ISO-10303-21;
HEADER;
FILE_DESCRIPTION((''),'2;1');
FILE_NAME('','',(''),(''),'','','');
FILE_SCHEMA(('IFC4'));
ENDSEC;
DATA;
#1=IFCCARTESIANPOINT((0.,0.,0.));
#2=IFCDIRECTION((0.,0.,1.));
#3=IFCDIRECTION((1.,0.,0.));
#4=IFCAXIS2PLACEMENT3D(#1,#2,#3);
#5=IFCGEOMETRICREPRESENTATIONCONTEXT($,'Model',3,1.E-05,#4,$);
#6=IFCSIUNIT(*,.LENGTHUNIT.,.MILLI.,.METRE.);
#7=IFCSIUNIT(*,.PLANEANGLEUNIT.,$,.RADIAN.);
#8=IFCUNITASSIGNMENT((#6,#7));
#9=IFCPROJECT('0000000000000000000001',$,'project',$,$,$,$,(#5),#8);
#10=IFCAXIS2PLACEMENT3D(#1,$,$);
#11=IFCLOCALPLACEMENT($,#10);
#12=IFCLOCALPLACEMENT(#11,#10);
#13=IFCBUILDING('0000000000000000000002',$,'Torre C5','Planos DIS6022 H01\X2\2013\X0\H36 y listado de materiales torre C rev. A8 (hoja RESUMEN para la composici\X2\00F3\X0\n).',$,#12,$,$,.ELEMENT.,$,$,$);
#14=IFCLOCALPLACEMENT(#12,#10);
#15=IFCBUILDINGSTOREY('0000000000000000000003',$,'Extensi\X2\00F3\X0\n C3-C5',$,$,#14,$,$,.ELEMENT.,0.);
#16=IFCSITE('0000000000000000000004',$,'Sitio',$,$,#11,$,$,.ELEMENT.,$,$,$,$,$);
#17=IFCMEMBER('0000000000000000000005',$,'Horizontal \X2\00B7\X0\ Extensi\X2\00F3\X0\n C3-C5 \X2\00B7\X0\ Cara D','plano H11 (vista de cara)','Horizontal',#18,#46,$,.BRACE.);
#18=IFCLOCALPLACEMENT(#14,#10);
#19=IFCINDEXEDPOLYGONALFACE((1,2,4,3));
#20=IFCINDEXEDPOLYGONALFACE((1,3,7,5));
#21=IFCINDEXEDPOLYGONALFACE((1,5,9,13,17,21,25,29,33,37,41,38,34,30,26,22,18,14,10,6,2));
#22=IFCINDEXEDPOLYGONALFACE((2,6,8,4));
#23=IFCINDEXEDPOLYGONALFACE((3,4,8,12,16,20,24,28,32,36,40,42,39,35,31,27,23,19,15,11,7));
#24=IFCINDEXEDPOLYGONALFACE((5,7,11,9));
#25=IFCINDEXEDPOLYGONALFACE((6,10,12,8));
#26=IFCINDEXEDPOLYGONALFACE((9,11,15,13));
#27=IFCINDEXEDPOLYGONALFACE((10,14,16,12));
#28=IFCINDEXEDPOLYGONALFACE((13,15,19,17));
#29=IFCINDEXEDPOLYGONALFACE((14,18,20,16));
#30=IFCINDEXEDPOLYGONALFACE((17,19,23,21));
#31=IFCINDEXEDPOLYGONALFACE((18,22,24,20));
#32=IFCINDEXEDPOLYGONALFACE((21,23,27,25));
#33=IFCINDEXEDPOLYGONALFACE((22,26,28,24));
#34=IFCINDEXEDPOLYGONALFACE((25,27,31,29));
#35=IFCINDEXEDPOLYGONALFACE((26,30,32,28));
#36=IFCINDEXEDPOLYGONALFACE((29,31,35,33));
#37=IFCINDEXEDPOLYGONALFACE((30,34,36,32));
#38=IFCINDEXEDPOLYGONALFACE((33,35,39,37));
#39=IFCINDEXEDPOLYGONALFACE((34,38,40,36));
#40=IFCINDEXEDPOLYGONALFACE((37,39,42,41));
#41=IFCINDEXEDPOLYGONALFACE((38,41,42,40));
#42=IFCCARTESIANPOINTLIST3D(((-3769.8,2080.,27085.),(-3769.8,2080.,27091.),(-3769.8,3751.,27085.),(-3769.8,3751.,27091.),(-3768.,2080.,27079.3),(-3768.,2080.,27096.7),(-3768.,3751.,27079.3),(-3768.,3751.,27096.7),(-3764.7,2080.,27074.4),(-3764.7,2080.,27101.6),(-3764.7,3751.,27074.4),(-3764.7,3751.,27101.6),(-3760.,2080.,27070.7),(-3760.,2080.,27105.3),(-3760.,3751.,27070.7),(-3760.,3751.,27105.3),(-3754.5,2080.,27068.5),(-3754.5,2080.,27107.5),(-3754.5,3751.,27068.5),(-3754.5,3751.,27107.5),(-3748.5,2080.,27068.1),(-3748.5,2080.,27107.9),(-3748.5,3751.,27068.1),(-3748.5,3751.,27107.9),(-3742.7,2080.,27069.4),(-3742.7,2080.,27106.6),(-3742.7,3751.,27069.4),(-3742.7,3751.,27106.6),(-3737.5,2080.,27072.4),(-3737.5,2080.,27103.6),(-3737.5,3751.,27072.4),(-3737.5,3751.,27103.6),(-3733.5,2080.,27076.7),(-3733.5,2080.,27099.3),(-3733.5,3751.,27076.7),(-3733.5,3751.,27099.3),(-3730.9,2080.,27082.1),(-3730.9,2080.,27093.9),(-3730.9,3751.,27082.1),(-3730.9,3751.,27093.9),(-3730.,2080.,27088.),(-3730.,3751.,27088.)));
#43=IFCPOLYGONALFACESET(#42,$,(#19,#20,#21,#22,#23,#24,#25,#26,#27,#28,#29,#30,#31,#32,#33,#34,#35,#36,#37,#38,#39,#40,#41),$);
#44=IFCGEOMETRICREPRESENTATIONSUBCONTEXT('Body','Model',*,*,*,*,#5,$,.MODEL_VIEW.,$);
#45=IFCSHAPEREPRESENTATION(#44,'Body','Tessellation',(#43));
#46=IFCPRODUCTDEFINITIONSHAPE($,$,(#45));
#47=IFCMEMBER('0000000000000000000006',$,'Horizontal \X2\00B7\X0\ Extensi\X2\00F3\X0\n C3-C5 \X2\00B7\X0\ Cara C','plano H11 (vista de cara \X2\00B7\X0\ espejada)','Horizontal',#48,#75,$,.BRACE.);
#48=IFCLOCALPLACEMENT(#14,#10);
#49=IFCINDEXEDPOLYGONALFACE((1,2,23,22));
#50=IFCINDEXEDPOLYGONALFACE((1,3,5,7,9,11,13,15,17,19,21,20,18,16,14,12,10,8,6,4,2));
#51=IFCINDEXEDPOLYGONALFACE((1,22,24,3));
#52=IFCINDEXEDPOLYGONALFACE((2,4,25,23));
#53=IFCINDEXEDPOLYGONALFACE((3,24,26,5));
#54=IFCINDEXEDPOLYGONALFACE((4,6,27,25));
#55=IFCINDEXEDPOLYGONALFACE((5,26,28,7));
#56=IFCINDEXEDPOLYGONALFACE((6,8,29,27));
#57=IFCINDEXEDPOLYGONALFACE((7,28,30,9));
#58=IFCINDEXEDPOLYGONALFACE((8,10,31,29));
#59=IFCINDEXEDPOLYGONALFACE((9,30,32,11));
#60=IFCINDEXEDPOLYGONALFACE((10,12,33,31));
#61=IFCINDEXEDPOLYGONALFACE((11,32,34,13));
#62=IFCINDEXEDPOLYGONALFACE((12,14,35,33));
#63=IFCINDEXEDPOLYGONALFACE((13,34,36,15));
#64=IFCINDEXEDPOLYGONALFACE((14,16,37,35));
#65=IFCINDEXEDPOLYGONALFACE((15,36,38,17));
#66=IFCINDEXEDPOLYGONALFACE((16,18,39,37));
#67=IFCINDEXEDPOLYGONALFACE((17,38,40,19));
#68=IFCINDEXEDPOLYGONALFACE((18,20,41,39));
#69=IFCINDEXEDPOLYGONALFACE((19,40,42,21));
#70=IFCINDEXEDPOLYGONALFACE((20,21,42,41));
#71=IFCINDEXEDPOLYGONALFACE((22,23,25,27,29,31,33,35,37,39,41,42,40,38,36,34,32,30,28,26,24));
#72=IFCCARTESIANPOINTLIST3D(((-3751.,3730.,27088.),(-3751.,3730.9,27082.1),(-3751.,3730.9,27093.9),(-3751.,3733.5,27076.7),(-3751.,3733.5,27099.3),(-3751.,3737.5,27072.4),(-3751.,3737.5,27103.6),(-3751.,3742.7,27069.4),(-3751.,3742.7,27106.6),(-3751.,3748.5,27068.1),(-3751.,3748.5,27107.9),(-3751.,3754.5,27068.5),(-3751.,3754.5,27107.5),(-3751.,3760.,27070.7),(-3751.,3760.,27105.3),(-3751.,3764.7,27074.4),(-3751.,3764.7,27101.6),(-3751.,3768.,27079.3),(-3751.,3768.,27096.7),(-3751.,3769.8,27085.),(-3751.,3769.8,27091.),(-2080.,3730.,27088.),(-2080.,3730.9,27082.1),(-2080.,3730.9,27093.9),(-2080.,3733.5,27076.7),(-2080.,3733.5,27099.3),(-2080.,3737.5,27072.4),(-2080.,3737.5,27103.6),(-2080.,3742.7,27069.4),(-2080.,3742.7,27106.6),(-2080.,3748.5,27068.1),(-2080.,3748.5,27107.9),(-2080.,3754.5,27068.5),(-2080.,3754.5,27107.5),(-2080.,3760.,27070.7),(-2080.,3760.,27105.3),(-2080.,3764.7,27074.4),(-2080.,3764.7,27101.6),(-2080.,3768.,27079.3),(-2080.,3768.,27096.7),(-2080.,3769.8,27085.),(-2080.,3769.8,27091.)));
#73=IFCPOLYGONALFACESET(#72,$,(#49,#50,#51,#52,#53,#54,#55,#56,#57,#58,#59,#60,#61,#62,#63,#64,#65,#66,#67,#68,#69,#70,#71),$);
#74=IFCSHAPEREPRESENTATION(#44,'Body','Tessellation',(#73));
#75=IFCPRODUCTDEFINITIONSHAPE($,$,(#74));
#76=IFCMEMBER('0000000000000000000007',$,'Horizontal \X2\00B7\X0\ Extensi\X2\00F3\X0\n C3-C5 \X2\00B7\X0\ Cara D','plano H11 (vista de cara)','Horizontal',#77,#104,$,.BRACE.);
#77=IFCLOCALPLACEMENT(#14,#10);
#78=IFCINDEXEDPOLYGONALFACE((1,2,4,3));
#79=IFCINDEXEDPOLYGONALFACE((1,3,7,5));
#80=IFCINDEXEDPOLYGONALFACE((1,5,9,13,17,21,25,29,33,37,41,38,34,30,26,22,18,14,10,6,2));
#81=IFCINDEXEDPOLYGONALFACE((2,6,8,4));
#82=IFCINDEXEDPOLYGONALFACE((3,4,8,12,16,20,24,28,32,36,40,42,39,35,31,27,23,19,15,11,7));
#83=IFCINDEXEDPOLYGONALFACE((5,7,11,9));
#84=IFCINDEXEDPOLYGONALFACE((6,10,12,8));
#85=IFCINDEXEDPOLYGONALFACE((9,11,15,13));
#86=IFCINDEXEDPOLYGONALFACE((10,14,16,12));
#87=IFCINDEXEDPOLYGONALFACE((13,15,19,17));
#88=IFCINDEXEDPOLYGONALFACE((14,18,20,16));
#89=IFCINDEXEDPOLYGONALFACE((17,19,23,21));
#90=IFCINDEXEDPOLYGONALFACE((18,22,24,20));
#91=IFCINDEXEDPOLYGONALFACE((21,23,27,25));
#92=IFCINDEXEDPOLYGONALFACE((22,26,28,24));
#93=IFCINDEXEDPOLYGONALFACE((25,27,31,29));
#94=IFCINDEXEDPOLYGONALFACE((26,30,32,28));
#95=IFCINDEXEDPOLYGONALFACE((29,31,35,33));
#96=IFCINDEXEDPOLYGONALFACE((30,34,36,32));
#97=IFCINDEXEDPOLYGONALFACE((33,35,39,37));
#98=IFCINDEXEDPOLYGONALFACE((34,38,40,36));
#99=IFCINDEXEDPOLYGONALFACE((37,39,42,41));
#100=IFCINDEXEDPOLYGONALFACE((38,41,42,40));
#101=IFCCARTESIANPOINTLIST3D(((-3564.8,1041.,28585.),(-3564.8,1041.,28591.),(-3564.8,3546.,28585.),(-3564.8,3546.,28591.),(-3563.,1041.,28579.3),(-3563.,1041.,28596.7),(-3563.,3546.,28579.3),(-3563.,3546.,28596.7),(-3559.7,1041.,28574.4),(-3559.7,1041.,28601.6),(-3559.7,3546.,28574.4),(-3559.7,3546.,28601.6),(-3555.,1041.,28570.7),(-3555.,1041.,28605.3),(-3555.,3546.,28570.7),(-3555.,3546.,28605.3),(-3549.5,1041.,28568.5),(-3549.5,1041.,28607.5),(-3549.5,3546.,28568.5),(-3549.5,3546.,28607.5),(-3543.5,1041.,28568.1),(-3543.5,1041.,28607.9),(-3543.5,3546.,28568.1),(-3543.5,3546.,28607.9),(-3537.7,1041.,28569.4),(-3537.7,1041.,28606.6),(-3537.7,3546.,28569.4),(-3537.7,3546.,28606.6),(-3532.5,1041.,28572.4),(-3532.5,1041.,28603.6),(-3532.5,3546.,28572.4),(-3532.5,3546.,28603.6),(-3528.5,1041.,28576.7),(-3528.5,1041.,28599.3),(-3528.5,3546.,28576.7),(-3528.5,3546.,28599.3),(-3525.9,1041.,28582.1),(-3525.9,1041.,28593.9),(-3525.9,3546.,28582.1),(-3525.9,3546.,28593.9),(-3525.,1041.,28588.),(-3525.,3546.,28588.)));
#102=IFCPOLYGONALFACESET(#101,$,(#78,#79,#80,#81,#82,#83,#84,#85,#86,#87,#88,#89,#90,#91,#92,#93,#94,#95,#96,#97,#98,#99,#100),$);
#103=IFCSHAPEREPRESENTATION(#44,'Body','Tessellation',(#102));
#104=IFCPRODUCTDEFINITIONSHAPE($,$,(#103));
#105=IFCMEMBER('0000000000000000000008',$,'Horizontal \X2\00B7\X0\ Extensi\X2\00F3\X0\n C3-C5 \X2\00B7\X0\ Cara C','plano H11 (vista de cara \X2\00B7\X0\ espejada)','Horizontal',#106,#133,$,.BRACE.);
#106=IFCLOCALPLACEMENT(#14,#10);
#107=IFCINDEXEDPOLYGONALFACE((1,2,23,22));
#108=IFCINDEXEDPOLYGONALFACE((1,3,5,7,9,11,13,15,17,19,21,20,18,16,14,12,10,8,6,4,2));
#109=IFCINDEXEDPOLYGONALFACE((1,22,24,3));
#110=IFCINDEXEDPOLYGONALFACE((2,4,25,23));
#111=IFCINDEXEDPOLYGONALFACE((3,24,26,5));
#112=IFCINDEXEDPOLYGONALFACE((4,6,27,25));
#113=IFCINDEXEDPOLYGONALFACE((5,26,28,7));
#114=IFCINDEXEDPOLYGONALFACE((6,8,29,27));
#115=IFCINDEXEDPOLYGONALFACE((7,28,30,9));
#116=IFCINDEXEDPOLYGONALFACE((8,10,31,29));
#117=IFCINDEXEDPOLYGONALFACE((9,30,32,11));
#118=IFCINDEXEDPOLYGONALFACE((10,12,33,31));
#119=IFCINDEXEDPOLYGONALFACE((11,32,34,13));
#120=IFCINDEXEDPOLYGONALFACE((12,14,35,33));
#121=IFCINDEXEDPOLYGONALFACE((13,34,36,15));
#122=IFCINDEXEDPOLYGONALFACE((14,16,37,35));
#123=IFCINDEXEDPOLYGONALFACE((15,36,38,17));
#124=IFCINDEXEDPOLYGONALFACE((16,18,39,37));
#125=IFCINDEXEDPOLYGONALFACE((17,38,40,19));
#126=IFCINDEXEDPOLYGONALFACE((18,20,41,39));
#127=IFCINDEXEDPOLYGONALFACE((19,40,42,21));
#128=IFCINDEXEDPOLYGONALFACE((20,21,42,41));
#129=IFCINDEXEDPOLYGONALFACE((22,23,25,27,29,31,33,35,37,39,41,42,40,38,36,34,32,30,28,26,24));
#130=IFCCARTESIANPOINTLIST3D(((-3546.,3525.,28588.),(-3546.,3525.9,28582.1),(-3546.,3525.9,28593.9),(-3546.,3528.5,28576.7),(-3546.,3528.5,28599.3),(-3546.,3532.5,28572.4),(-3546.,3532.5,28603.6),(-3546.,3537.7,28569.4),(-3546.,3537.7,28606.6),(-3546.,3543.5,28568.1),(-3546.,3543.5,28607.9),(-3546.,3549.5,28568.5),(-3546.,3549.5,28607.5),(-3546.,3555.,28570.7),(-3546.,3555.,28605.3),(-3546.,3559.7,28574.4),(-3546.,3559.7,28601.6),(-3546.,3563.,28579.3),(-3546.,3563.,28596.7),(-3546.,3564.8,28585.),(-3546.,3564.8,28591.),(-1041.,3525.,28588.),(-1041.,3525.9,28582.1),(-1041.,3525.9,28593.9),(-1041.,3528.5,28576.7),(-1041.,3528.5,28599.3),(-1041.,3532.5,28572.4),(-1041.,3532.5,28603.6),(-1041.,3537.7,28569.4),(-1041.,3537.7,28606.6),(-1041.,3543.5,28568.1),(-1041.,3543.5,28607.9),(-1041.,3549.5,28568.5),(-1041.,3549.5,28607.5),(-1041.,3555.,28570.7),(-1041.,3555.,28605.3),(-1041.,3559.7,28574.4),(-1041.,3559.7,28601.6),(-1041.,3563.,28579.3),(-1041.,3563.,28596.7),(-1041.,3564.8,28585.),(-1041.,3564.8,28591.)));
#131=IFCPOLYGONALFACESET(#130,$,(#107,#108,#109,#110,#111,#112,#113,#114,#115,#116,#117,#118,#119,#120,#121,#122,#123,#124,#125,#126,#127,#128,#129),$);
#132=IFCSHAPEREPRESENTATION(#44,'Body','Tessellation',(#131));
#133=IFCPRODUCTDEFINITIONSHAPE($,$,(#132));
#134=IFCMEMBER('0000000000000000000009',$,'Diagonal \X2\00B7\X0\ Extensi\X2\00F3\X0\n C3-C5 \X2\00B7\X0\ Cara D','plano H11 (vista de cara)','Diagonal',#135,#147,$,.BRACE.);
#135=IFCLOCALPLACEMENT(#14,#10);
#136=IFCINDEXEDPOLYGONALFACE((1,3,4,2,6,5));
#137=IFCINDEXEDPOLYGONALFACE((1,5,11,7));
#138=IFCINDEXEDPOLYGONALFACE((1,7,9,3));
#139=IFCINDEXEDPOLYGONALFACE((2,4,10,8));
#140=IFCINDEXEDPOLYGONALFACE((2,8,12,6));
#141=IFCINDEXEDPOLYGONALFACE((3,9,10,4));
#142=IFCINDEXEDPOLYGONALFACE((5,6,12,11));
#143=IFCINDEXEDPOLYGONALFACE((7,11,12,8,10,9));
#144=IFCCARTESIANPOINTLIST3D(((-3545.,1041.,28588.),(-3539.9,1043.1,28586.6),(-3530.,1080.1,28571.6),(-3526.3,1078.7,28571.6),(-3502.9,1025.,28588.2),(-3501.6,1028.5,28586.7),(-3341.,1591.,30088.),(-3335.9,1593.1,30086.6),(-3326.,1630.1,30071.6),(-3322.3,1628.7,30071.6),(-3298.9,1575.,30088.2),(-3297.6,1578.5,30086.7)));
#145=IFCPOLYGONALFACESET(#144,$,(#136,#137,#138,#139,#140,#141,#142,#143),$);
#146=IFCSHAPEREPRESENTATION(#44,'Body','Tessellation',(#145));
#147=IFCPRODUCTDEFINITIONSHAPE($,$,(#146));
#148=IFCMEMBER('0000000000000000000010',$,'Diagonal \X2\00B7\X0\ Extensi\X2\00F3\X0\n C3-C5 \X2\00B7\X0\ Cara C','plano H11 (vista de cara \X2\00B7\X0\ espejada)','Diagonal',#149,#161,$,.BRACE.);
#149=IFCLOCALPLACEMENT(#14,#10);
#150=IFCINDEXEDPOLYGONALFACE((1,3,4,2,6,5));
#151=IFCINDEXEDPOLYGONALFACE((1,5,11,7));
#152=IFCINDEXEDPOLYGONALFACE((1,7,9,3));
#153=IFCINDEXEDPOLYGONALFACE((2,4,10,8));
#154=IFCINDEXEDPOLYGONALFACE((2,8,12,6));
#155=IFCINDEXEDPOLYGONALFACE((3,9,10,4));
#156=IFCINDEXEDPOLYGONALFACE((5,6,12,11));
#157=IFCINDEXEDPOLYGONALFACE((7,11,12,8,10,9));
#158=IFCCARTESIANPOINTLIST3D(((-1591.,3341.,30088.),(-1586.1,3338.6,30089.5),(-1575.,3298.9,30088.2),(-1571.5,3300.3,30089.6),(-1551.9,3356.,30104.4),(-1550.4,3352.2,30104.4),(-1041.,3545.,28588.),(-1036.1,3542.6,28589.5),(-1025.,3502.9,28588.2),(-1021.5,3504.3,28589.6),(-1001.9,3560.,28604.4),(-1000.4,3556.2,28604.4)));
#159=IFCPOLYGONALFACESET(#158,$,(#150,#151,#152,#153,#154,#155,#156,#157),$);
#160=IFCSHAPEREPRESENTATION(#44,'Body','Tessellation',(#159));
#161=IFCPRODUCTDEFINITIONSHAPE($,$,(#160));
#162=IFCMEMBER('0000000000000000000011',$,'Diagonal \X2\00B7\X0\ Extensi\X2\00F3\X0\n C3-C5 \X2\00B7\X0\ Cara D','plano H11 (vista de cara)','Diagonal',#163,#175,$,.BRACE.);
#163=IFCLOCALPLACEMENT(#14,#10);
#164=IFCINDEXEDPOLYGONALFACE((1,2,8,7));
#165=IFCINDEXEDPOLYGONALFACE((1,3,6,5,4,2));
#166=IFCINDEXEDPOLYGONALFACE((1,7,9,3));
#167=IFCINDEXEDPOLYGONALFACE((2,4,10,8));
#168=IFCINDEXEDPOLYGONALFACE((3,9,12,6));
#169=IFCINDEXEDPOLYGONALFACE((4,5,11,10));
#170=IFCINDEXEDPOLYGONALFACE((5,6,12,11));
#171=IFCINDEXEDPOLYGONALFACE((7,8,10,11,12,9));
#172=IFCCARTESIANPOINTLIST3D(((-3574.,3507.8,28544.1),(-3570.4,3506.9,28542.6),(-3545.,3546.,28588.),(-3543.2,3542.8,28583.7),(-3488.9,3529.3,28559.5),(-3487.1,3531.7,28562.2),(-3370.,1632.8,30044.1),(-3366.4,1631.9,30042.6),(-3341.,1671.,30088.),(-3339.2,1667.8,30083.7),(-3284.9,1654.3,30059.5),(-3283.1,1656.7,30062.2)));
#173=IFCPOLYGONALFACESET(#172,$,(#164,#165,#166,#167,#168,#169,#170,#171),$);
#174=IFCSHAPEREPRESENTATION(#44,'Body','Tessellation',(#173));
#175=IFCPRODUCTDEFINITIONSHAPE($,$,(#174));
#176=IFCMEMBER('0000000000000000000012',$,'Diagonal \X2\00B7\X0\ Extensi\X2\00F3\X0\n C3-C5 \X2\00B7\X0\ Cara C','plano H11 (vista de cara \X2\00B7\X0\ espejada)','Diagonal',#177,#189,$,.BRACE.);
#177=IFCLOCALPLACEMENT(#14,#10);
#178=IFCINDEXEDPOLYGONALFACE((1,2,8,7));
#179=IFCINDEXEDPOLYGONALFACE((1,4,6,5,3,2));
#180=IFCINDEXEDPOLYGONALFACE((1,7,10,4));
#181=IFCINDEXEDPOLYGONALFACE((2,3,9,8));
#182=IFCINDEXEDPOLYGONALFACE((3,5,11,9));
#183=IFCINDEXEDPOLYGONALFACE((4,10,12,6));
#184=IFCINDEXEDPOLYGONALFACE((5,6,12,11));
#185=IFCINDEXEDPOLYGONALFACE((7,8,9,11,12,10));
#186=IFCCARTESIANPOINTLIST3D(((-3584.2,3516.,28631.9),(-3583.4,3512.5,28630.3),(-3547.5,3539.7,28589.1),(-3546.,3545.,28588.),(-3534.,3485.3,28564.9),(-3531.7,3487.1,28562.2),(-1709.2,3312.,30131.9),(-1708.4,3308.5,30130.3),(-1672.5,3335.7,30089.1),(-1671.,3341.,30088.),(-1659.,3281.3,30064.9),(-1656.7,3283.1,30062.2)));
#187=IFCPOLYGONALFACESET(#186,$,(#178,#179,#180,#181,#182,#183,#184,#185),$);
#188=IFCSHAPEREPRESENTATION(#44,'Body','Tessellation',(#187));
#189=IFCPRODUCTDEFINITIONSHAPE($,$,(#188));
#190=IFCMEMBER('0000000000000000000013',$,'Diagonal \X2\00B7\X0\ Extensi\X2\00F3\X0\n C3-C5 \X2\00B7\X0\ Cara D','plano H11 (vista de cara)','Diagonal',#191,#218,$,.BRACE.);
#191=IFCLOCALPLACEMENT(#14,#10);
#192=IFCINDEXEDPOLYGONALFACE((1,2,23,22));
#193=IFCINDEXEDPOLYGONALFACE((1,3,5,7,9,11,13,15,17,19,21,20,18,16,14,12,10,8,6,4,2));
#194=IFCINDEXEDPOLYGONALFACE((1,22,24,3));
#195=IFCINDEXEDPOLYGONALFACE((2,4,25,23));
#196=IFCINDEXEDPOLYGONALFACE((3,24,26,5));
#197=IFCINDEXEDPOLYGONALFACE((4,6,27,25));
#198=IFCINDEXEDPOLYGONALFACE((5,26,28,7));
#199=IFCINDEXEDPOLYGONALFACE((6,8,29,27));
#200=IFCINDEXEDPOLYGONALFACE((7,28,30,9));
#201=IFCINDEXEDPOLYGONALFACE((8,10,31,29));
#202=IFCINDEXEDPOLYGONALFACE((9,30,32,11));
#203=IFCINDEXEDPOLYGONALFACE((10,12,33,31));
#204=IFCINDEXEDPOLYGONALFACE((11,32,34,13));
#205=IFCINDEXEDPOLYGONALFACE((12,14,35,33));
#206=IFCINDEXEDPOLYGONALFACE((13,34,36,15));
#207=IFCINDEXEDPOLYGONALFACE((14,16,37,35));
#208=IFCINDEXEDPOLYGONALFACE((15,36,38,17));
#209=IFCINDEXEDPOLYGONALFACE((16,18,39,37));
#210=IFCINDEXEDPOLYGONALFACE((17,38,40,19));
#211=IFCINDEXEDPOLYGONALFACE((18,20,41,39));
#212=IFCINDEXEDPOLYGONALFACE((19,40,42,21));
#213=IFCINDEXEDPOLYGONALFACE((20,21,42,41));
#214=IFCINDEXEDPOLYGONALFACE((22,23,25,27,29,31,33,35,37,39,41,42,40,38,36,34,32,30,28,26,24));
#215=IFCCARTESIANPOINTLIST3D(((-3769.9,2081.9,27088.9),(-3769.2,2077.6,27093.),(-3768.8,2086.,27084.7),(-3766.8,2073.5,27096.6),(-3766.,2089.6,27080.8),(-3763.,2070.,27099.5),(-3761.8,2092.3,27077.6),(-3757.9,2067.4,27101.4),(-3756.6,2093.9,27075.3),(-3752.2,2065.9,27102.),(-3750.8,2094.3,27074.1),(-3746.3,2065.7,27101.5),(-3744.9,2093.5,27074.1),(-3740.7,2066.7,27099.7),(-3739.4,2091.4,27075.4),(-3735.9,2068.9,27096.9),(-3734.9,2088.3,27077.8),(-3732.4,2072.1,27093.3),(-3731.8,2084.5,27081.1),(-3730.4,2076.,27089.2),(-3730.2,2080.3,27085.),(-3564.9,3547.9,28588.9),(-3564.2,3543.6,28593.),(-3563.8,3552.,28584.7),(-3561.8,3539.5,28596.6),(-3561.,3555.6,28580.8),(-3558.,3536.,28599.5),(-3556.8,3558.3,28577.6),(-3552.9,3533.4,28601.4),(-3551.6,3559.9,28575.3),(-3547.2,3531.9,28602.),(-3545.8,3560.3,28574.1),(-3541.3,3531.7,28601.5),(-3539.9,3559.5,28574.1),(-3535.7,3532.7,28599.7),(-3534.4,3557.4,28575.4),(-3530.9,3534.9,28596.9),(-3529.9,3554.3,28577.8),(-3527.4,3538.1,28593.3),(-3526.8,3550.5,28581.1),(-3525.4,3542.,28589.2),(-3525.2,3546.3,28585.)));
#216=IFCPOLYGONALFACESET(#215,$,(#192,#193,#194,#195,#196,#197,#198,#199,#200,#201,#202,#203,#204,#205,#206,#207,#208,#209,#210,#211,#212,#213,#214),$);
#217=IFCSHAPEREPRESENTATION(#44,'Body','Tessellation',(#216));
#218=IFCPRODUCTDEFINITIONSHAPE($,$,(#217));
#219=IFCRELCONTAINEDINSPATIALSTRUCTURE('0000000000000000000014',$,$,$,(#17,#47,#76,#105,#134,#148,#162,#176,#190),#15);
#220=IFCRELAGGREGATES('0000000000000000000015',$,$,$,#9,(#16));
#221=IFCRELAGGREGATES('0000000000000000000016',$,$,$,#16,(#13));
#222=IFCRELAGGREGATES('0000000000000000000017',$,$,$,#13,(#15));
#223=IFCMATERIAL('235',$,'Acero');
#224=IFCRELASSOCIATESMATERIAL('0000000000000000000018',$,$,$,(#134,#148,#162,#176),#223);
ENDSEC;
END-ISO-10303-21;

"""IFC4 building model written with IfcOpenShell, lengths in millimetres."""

from ifc_helpers import new_model, si_unit, frame, frame_2d, origin, origin_with_axes, place, context, subcontext, project, spatial, circle, l_section, extrude, material, element, save


model = new_model("IFC4")

# Units and contexts
model_context = context("Model", 3, precision=1e-05, world=origin_with_axes())
body_context = subcontext(model_context, "Body", "Model", "MODEL_VIEW")
ifc_project = project(units=[si_unit("LENGTHUNIT", "METRE", prefix="MILLI"), si_unit("PLANEANGLEUNIT", "RADIAN")], contexts=[model_context])

# Site, building, storey
site_placement = place(None, origin())
site = spatial("IfcSite", under=ifc_project, at=site_placement, Name="Sitio", CompositionType="ELEMENT")
building_placement = place(site_placement, origin())
building = spatial("IfcBuilding", under=site, at=building_placement, Name="Torre C5", Description="Planos DIS6022 H01–H36 y listado de materiales torre C rev. A8 (hoja RESUMEN para la composición).", CompositionType="ELEMENT")
storey_placement = place(building_placement, origin())
storey = spatial("IfcBuildingStorey", under=building, at=storey_placement, Name="Extensión C3-C5", CompositionType="ELEMENT", Elevation=0.0)

# Members
for number, where, z_axis, x_axis, name, description in (
    (1, (-3750.0, 2080.0, 27088.0), (0.0, 1.0, 0.0), (1.0, 0.0, 0.0), "Horizontal · Extensión C3-C5 · Cara D", "plano H11 (vista de cara)"),
    (2, (-2080.0, 3750.0, 27088.0), (-1.0, 0.0, 0.0), (0.0, -1.0, 0.0), "Horizontal · Extensión C3-C5 · Cara C", "plano H11 (vista de cara · espejada)"),
):
    element("IfcMember", number, at=place(storey_placement, frame(where, z_axis=z_axis, x_axis=x_axis)), inside=storey, Name=name, Description=description, ObjectType="Horizontal", PredefinedType="BRACE", context=body_context, shape_type="SweptSolid", body=[
        extrude(circle(Radius=20.0), None, (0.0, 0.0, 1.0), 1671.0),
    ])
for number, where, z_axis, x_axis, name, description in (
    (3, (-3545.0, 1041.0, 28588.0), (0.0, 1.0, 0.0), (1.0, 0.0, 0.0), "Horizontal · Extensión C3-C5 · Cara D", "plano H11 (vista de cara)"),
    (4, (-1041.0, 3545.0, 28588.0), (-1.0, 0.0, 0.0), (0.0, -1.0, 0.0), "Horizontal · Extensión C3-C5 · Cara C", "plano H11 (vista de cara · espejada)"),
):
    element("IfcMember", number, at=place(storey_placement, frame(where, z_axis=z_axis, x_axis=x_axis)), inside=storey, Name=name, Description=description, ObjectType="Horizontal", PredefinedType="BRACE", context=body_context, shape_type="SweptSolid", body=[
        extrude(circle(Radius=20.0), None, (0.0, 0.0, 1.0), 2505.0),
    ])
ifc_material_1 = material(Name="235", Category="Acero")
for number, where, z_axis, x_axis, name, description in (
    (5, (-3545.0, 1041.0, 28588.0), (0.126659, 0.341482, 0.931315), (0.934555, -0.355803, 0.003362), "Diagonal · Extensión C3-C5 · Cara D", "plano H11 (vista de cara)"),
    (6, (-1041.0, 3545.0, 28588.0), (-0.341482, -0.126659, 0.931315), (0.355803, -0.934555, 0.003362), "Diagonal · Extensión C3-C5 · Cara C", "plano H11 (vista de cara · espejada)"),
):
    element("IfcMember", number, at=place(storey_placement, frame(where, z_axis=z_axis, x_axis=x_axis)), inside=storey, material=ifc_material_1, Name=name, Description=description, ObjectType="Diagonal", PredefinedType="BRACE", context=body_context, shape_type="SweptSolid", body=[
        extrude(l_section(Depth=45.0, Width=45.0, Thickness=4.0, at=frame_2d((22.5, 22.5))), None, (0.0, 0.0, 1.0), 1610.6),
    ])
for number, where, z_axis, x_axis, name, description in (
    (7, (-3341.0, 1671.0, 30088.0), (-0.084654, 0.778066, -0.622453), (0.891172, -0.220307, -0.396583), "Diagonal · Extensión C3-C5 · Cara D", "plano H11 (vista de cara)"),
    (8, (-1671.0, 3341.0, 30088.0), (-0.778066, 0.084654, -0.622453), (0.220307, -0.891172, -0.396583), "Diagonal · Extensión C3-C5 · Cara C", "plano H11 (vista de cara · espejada)"),
):
    element("IfcMember", number, at=place(storey_placement, frame(where, z_axis=z_axis, x_axis=x_axis)), inside=storey, material=ifc_material_1, Name=name, Description=description, ObjectType="Diagonal", PredefinedType="BRACE", context=body_context, shape_type="SweptSolid", body=[
        extrude(l_section(Depth=65.0, Width=65.0, Thickness=4.0, at=frame_2d((32.5, 32.5))), None, (0.0, 0.0, 1.0), 2409.8),
    ])
for number, where, z_axis, x_axis, name in (
    (9, (-3545.0, 3546.0, 28588.0), (-0.097276, -0.69564, -0.711774), (0.880677, -0.39331, 0.264036), "Diagonal · Extensión C3-C5 · Cara D"),
):
    element("IfcMember", number, at=place(storey_placement, frame(where, z_axis=z_axis, x_axis=x_axis)), inside=storey, Name=name, Description="plano H11 (vista de cara)", ObjectType="Diagonal", PredefinedType="BRACE", context=body_context, shape_type="SweptSolid", body=[
        extrude(circle(Radius=20.0), None, (0.0, 0.0, 1.0), 2107.4),
    ])

save(model, "model.ifc")
